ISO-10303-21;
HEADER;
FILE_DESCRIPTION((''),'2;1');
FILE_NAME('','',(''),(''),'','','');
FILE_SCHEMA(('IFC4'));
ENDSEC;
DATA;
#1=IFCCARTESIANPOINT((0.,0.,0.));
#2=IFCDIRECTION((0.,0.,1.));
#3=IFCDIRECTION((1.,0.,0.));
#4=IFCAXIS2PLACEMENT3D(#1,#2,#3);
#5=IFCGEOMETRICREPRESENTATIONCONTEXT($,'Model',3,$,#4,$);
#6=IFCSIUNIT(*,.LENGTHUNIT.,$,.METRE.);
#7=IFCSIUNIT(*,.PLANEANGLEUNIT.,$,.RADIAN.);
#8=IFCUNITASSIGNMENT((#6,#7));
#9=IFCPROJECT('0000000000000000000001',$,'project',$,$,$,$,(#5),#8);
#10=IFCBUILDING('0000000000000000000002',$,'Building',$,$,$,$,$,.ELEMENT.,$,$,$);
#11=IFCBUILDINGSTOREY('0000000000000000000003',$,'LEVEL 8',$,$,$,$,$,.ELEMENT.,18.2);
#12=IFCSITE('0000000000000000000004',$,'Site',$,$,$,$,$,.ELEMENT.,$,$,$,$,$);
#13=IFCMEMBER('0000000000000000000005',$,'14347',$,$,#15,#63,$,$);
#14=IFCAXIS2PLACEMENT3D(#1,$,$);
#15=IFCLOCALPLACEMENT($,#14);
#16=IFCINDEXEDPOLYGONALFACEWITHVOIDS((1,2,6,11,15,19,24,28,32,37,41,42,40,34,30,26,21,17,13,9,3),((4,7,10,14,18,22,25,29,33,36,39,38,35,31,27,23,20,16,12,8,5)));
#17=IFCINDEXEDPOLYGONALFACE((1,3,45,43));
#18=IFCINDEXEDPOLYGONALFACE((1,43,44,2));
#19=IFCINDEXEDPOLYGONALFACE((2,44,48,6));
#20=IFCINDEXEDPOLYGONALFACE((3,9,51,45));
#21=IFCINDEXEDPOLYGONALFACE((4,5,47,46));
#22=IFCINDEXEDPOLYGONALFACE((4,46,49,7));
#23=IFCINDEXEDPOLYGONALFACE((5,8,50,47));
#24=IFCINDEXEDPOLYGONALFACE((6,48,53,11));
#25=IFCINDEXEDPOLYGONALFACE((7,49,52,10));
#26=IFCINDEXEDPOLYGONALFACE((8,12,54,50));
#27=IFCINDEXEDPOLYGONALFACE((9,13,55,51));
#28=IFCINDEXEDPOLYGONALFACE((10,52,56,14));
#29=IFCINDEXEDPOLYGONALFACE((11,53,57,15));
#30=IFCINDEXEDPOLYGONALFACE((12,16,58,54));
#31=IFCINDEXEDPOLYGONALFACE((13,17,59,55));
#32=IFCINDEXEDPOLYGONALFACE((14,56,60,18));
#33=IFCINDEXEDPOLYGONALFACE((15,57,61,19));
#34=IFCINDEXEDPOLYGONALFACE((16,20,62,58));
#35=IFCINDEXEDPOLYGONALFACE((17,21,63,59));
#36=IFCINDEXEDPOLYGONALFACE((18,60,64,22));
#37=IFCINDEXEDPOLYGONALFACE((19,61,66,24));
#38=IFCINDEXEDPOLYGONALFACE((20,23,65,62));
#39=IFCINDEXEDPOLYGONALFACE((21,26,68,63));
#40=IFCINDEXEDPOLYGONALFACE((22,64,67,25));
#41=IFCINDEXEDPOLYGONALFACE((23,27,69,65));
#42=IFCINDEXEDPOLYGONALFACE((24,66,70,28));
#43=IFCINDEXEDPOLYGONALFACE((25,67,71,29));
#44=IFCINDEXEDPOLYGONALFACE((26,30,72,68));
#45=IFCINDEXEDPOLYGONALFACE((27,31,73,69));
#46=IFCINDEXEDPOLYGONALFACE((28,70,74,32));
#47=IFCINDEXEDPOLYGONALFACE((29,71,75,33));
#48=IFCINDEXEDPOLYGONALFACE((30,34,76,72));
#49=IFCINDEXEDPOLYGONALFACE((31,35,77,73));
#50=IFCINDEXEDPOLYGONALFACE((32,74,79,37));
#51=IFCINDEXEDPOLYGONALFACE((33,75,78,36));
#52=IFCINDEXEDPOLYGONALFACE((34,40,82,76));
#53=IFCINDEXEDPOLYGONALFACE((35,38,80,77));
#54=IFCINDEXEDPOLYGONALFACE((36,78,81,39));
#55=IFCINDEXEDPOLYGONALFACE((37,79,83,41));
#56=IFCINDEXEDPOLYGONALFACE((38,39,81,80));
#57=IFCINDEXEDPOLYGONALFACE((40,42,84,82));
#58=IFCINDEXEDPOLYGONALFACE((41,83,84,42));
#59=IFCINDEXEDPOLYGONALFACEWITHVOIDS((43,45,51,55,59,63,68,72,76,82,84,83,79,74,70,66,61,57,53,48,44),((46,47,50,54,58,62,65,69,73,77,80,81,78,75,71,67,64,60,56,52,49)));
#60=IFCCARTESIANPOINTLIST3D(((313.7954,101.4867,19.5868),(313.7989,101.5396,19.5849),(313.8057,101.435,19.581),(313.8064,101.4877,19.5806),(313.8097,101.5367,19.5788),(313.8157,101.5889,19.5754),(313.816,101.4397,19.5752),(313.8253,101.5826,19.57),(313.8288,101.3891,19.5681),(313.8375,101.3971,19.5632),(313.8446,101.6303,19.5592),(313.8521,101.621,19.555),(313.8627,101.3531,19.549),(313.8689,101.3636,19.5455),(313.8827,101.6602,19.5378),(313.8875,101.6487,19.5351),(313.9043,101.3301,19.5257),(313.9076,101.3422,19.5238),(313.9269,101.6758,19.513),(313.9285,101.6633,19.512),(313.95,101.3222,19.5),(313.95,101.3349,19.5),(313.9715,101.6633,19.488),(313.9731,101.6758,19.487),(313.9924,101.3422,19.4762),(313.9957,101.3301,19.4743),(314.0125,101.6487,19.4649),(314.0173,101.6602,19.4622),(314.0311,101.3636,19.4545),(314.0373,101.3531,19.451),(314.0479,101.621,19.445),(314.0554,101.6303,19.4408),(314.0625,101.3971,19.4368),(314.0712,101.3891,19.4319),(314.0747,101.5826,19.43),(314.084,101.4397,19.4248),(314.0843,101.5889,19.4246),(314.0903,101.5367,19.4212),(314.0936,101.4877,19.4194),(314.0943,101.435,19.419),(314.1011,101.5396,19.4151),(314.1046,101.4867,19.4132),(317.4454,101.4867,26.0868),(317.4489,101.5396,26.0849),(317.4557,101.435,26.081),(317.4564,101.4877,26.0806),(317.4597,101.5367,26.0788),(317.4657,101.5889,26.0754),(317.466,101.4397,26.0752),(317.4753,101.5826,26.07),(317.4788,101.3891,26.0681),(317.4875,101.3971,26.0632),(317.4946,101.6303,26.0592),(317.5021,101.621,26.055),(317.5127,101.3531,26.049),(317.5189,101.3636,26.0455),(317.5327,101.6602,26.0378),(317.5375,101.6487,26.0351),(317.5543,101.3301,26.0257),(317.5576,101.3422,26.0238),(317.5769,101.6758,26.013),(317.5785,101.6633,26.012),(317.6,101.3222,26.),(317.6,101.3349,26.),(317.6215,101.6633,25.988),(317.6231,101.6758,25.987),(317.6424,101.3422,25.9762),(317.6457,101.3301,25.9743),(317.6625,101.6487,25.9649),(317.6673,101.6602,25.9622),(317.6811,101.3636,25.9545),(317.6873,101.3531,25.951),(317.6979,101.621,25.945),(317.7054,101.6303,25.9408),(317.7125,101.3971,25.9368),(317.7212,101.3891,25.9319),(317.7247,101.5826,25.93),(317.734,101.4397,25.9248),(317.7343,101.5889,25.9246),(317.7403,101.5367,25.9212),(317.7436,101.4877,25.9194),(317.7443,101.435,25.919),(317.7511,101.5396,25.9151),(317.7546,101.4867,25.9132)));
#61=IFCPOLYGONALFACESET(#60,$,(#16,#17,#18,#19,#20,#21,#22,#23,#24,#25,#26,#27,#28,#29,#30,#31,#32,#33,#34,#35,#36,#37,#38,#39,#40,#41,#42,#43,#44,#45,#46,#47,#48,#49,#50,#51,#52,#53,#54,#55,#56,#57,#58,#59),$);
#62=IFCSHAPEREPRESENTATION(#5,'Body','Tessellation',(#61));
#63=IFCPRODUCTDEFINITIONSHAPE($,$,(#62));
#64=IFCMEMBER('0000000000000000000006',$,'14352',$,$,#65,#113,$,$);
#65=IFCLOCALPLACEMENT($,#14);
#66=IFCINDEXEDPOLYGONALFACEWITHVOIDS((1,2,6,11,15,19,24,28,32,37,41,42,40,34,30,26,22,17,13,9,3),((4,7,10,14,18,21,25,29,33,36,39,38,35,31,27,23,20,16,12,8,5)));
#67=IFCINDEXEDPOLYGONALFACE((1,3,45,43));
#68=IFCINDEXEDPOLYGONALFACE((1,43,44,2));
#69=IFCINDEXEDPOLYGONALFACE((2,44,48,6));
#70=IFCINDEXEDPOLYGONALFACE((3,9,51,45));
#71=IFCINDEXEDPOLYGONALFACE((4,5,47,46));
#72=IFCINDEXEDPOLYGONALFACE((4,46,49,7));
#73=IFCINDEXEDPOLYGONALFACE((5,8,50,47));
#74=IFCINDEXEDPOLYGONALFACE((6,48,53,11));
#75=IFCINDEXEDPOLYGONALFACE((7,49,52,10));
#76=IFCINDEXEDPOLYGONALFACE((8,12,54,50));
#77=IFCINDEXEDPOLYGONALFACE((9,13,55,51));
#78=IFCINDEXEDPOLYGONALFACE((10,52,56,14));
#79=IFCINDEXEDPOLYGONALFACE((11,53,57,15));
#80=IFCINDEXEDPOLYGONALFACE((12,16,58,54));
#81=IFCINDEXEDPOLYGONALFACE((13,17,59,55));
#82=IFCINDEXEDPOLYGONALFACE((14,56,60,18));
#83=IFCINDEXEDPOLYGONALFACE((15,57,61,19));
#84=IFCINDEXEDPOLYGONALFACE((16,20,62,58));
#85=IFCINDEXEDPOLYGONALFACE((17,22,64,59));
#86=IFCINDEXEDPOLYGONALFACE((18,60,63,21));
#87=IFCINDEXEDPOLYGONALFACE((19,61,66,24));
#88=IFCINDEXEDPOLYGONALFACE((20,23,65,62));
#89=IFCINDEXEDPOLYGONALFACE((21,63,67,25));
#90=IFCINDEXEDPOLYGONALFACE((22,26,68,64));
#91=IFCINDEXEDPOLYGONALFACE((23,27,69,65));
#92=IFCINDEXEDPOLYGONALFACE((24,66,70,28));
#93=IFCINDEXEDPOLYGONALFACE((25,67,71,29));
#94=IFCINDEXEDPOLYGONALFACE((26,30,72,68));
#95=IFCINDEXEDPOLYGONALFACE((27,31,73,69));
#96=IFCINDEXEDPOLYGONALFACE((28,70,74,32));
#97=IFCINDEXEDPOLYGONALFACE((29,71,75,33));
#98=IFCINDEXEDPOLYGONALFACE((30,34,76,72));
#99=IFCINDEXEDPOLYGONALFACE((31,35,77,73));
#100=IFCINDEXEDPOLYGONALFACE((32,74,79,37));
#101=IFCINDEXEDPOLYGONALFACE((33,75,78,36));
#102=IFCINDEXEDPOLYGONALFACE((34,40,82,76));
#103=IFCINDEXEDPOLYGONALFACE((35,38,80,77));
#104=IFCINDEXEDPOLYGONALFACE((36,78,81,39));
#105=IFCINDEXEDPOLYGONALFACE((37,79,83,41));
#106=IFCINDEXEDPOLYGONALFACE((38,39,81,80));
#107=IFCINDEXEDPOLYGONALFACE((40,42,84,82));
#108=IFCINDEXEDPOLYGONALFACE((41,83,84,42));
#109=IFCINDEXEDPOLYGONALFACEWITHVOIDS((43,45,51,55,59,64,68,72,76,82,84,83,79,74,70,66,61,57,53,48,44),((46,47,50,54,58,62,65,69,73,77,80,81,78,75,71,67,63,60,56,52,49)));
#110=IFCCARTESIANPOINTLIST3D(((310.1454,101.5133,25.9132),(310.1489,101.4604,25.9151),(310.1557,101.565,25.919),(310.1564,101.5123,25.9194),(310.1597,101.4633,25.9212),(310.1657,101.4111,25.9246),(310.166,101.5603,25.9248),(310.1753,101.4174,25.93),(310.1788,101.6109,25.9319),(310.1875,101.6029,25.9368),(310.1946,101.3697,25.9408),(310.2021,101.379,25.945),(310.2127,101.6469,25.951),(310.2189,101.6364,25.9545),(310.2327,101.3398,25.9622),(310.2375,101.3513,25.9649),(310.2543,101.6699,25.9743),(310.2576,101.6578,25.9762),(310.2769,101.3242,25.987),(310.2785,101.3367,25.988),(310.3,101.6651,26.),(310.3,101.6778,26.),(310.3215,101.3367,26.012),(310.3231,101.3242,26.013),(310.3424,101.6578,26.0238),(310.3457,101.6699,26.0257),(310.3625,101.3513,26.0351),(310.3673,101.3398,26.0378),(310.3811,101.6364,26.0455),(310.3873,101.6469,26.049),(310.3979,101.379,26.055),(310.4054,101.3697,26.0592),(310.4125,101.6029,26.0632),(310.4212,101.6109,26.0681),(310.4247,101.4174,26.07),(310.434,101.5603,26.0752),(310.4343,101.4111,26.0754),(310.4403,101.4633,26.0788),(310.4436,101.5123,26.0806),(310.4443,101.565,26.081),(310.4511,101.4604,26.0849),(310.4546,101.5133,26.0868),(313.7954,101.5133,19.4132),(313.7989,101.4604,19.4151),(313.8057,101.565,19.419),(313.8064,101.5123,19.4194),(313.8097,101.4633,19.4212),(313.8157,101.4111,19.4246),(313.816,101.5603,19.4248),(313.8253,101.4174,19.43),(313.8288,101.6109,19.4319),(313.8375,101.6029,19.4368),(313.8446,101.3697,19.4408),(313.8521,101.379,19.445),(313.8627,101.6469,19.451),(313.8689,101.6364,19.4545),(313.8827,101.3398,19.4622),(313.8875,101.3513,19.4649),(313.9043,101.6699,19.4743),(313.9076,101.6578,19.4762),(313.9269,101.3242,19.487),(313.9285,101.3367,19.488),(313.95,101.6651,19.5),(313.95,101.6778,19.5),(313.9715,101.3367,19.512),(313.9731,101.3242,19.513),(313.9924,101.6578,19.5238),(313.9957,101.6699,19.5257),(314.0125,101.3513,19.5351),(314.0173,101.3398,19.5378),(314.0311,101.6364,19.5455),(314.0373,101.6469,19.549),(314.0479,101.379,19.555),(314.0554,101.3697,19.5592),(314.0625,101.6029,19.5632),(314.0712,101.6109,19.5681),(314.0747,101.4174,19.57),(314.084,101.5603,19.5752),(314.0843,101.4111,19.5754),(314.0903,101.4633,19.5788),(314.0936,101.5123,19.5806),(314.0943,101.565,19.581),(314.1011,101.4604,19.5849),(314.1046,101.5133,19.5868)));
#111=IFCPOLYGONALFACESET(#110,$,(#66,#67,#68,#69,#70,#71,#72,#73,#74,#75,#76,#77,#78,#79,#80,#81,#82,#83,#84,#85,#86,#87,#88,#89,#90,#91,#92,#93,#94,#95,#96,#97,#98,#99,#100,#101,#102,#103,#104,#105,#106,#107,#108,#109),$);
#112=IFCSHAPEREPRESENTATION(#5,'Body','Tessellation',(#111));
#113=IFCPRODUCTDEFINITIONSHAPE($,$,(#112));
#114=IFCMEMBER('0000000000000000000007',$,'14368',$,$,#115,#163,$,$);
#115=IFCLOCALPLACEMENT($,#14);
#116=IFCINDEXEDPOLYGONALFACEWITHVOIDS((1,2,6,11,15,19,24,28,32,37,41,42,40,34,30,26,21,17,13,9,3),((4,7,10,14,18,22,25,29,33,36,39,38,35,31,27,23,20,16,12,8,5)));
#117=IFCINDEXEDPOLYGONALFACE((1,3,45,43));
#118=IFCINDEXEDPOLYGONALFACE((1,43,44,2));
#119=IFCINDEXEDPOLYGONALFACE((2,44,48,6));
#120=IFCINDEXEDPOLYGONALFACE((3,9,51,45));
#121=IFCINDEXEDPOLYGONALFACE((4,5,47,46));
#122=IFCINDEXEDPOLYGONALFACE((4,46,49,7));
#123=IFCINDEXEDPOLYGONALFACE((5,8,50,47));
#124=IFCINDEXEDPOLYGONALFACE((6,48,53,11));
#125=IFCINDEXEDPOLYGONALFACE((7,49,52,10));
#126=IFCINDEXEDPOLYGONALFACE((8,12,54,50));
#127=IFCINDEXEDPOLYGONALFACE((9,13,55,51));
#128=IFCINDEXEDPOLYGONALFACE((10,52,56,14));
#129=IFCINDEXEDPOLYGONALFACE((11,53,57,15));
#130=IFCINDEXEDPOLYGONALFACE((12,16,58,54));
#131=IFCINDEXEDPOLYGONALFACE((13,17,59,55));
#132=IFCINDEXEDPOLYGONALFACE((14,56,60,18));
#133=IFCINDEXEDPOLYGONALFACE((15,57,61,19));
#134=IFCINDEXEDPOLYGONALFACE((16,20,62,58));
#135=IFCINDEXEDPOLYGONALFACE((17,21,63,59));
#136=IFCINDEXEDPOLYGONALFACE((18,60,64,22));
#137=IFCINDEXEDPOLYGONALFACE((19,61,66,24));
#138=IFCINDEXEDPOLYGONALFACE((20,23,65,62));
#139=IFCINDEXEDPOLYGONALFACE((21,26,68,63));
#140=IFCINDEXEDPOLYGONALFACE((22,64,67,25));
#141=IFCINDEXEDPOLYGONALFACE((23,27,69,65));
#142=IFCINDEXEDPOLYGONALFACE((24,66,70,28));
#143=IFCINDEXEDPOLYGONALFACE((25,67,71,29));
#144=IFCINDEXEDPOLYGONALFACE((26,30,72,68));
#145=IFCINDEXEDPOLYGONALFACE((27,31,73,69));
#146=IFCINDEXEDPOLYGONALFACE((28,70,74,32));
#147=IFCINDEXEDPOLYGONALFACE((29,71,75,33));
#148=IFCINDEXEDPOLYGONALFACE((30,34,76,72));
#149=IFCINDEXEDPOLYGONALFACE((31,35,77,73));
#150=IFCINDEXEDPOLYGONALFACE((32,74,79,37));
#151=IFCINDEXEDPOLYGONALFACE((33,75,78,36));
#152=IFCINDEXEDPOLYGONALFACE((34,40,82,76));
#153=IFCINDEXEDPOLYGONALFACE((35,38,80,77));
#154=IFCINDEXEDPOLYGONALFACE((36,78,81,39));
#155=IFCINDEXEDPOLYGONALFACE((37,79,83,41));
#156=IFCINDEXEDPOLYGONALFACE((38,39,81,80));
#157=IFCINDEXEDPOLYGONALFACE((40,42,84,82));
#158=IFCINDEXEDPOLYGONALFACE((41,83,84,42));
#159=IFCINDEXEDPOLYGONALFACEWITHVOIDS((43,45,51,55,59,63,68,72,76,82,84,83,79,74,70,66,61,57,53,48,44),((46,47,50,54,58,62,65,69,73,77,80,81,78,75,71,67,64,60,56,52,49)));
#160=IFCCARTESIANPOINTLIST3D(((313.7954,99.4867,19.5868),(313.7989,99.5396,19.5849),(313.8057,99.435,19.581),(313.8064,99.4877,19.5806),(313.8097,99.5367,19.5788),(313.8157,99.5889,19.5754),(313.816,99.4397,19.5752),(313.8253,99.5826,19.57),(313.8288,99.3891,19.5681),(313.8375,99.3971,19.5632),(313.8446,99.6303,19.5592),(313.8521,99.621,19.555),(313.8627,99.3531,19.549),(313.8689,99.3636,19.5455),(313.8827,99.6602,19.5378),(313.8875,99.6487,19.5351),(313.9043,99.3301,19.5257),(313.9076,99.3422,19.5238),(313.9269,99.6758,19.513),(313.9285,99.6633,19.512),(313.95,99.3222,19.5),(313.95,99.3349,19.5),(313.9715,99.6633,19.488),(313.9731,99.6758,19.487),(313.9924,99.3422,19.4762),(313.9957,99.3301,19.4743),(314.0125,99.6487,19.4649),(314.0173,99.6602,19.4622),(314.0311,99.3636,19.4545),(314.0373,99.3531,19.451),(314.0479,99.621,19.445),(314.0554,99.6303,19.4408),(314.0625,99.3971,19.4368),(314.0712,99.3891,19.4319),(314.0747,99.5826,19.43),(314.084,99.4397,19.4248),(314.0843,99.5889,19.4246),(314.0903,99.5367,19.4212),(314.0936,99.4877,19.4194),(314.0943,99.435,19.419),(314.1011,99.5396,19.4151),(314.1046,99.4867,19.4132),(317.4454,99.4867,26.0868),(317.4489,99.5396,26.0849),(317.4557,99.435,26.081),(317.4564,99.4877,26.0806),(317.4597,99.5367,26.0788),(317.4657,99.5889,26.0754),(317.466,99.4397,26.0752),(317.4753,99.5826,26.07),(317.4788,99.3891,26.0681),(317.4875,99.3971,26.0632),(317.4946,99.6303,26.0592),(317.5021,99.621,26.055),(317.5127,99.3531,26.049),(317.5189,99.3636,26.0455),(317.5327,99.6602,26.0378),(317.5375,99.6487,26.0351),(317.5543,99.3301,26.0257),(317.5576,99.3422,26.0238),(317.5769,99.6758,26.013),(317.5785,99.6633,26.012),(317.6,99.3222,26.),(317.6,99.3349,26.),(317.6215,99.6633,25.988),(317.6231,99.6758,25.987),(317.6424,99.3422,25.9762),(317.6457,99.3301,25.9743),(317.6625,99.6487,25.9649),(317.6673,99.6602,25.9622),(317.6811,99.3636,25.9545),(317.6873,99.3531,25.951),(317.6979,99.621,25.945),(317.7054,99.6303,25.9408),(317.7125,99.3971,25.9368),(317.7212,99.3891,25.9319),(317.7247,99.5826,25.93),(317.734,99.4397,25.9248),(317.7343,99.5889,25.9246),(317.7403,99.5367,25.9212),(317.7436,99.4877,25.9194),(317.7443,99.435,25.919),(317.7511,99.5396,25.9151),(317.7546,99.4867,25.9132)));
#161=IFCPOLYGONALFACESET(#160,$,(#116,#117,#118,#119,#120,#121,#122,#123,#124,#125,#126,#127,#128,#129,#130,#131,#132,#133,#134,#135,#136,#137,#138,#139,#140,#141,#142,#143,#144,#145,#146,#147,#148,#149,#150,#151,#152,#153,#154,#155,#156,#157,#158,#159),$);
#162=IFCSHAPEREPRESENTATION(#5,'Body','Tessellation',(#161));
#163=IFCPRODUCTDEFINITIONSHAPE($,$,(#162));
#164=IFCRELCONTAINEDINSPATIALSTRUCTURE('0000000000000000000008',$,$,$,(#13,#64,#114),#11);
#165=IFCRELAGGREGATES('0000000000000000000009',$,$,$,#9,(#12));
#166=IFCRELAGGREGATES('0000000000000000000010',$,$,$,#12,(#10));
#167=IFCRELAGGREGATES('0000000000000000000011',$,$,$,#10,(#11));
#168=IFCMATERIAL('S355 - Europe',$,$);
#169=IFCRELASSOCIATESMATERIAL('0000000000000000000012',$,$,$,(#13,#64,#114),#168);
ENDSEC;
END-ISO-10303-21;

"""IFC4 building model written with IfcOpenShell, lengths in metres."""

from ifc_helpers import new_model, si_unit, frame, origin_with_axes, origin_2d_with_axis, place, context, project, spatial, hollow_circle, extrude, material, material_profile, profile_set, profile_usage, element, save


model = new_model("IFC4")

# Units and contexts
model_context = context("Model", 3, world=origin_with_axes())
ifc_project = project(units=[si_unit("LENGTHUNIT", "METRE"), si_unit("PLANEANGLEUNIT", "RADIAN")], contexts=[model_context])

# Site, building, storey
site = spatial("IfcSite", under=ifc_project, Name="Site", CompositionType="ELEMENT")
building = spatial("IfcBuilding", under=site, Name="Building", CompositionType="ELEMENT")
storey = spatial("IfcBuildingStorey", under=building, Name="LEVEL 8", CompositionType="ELEMENT", Elevation=18.2)

# Shared definitions
ifc_material = material(Name="S355 - Europe")

# Members
ifc_material_profile_1 = material_profile(ifc_material, hollow_circle(Radius=0.1778, WallThickness=0.0127, at=origin_2d_with_axis()))
ifc_profile_set_1 = profile_set([ifc_material_profile_1])
ifc_profile_usage_1 = profile_usage(ifc_profile_set_1, cardinal=10)
member_1_placement = place(None, frame((317.6, 101.5, 26.0), z_axis=(-0.489624, 0.0, -0.871934), x_axis=(0.0, -1.0, 0.0)))
element("IfcMember", 1, at=member_1_placement, inside=storey, material=ifc_profile_usage_1, Name="14347", context=model_context, shape_type="SweptSolid", body=[
    extrude(hollow_circle(Radius=0.1778, WallThickness=0.0127, at=origin_2d_with_axis()), origin_with_axes(), (0.0, 0.0, 1.0), 7.4547),
])
ifc_material_profile_2 = material_profile(ifc_material, hollow_circle(Radius=0.1778, WallThickness=0.0127, at=origin_2d_with_axis()))
ifc_profile_set_2 = profile_set([ifc_material_profile_2])
ifc_profile_usage_2 = profile_usage(ifc_profile_set_2, cardinal=10)
member_2_placement = place(None, frame((310.3, 101.5, 26.0), z_axis=(0.489624, 0.0, -0.871934), x_axis=(0.0, 1.0, 0.0)))
element("IfcMember", 2, at=member_2_placement, inside=storey, material=ifc_profile_usage_2, Name="14352", context=model_context, shape_type="SweptSolid", body=[
    extrude(hollow_circle(Radius=0.1778, WallThickness=0.0127, at=origin_2d_with_axis()), origin_with_axes(), (0.0, 0.0, 1.0), 7.4547),
])
ifc_material_profile_3 = material_profile(ifc_material, hollow_circle(Radius=0.1778, WallThickness=0.0127, at=origin_2d_with_axis()))
ifc_profile_set_3 = profile_set([ifc_material_profile_3])
ifc_profile_usage_3 = profile_usage(ifc_profile_set_3, cardinal=10)
member_3_placement = place(None, frame((317.6, 99.5, 26.0), z_axis=(-0.489624, 0.0, -0.871934), x_axis=(0.0, -1.0, 0.0)))
element("IfcMember", 3, at=member_3_placement, inside=storey, material=ifc_profile_usage_3, Name="14368", context=model_context, shape_type="SweptSolid", body=[
    extrude(hollow_circle(Radius=0.1778, WallThickness=0.0127, at=origin_2d_with_axis()), origin_with_axes(), (0.0, 0.0, 1.0), 7.4547),
])

save(model, "model.ifc")
